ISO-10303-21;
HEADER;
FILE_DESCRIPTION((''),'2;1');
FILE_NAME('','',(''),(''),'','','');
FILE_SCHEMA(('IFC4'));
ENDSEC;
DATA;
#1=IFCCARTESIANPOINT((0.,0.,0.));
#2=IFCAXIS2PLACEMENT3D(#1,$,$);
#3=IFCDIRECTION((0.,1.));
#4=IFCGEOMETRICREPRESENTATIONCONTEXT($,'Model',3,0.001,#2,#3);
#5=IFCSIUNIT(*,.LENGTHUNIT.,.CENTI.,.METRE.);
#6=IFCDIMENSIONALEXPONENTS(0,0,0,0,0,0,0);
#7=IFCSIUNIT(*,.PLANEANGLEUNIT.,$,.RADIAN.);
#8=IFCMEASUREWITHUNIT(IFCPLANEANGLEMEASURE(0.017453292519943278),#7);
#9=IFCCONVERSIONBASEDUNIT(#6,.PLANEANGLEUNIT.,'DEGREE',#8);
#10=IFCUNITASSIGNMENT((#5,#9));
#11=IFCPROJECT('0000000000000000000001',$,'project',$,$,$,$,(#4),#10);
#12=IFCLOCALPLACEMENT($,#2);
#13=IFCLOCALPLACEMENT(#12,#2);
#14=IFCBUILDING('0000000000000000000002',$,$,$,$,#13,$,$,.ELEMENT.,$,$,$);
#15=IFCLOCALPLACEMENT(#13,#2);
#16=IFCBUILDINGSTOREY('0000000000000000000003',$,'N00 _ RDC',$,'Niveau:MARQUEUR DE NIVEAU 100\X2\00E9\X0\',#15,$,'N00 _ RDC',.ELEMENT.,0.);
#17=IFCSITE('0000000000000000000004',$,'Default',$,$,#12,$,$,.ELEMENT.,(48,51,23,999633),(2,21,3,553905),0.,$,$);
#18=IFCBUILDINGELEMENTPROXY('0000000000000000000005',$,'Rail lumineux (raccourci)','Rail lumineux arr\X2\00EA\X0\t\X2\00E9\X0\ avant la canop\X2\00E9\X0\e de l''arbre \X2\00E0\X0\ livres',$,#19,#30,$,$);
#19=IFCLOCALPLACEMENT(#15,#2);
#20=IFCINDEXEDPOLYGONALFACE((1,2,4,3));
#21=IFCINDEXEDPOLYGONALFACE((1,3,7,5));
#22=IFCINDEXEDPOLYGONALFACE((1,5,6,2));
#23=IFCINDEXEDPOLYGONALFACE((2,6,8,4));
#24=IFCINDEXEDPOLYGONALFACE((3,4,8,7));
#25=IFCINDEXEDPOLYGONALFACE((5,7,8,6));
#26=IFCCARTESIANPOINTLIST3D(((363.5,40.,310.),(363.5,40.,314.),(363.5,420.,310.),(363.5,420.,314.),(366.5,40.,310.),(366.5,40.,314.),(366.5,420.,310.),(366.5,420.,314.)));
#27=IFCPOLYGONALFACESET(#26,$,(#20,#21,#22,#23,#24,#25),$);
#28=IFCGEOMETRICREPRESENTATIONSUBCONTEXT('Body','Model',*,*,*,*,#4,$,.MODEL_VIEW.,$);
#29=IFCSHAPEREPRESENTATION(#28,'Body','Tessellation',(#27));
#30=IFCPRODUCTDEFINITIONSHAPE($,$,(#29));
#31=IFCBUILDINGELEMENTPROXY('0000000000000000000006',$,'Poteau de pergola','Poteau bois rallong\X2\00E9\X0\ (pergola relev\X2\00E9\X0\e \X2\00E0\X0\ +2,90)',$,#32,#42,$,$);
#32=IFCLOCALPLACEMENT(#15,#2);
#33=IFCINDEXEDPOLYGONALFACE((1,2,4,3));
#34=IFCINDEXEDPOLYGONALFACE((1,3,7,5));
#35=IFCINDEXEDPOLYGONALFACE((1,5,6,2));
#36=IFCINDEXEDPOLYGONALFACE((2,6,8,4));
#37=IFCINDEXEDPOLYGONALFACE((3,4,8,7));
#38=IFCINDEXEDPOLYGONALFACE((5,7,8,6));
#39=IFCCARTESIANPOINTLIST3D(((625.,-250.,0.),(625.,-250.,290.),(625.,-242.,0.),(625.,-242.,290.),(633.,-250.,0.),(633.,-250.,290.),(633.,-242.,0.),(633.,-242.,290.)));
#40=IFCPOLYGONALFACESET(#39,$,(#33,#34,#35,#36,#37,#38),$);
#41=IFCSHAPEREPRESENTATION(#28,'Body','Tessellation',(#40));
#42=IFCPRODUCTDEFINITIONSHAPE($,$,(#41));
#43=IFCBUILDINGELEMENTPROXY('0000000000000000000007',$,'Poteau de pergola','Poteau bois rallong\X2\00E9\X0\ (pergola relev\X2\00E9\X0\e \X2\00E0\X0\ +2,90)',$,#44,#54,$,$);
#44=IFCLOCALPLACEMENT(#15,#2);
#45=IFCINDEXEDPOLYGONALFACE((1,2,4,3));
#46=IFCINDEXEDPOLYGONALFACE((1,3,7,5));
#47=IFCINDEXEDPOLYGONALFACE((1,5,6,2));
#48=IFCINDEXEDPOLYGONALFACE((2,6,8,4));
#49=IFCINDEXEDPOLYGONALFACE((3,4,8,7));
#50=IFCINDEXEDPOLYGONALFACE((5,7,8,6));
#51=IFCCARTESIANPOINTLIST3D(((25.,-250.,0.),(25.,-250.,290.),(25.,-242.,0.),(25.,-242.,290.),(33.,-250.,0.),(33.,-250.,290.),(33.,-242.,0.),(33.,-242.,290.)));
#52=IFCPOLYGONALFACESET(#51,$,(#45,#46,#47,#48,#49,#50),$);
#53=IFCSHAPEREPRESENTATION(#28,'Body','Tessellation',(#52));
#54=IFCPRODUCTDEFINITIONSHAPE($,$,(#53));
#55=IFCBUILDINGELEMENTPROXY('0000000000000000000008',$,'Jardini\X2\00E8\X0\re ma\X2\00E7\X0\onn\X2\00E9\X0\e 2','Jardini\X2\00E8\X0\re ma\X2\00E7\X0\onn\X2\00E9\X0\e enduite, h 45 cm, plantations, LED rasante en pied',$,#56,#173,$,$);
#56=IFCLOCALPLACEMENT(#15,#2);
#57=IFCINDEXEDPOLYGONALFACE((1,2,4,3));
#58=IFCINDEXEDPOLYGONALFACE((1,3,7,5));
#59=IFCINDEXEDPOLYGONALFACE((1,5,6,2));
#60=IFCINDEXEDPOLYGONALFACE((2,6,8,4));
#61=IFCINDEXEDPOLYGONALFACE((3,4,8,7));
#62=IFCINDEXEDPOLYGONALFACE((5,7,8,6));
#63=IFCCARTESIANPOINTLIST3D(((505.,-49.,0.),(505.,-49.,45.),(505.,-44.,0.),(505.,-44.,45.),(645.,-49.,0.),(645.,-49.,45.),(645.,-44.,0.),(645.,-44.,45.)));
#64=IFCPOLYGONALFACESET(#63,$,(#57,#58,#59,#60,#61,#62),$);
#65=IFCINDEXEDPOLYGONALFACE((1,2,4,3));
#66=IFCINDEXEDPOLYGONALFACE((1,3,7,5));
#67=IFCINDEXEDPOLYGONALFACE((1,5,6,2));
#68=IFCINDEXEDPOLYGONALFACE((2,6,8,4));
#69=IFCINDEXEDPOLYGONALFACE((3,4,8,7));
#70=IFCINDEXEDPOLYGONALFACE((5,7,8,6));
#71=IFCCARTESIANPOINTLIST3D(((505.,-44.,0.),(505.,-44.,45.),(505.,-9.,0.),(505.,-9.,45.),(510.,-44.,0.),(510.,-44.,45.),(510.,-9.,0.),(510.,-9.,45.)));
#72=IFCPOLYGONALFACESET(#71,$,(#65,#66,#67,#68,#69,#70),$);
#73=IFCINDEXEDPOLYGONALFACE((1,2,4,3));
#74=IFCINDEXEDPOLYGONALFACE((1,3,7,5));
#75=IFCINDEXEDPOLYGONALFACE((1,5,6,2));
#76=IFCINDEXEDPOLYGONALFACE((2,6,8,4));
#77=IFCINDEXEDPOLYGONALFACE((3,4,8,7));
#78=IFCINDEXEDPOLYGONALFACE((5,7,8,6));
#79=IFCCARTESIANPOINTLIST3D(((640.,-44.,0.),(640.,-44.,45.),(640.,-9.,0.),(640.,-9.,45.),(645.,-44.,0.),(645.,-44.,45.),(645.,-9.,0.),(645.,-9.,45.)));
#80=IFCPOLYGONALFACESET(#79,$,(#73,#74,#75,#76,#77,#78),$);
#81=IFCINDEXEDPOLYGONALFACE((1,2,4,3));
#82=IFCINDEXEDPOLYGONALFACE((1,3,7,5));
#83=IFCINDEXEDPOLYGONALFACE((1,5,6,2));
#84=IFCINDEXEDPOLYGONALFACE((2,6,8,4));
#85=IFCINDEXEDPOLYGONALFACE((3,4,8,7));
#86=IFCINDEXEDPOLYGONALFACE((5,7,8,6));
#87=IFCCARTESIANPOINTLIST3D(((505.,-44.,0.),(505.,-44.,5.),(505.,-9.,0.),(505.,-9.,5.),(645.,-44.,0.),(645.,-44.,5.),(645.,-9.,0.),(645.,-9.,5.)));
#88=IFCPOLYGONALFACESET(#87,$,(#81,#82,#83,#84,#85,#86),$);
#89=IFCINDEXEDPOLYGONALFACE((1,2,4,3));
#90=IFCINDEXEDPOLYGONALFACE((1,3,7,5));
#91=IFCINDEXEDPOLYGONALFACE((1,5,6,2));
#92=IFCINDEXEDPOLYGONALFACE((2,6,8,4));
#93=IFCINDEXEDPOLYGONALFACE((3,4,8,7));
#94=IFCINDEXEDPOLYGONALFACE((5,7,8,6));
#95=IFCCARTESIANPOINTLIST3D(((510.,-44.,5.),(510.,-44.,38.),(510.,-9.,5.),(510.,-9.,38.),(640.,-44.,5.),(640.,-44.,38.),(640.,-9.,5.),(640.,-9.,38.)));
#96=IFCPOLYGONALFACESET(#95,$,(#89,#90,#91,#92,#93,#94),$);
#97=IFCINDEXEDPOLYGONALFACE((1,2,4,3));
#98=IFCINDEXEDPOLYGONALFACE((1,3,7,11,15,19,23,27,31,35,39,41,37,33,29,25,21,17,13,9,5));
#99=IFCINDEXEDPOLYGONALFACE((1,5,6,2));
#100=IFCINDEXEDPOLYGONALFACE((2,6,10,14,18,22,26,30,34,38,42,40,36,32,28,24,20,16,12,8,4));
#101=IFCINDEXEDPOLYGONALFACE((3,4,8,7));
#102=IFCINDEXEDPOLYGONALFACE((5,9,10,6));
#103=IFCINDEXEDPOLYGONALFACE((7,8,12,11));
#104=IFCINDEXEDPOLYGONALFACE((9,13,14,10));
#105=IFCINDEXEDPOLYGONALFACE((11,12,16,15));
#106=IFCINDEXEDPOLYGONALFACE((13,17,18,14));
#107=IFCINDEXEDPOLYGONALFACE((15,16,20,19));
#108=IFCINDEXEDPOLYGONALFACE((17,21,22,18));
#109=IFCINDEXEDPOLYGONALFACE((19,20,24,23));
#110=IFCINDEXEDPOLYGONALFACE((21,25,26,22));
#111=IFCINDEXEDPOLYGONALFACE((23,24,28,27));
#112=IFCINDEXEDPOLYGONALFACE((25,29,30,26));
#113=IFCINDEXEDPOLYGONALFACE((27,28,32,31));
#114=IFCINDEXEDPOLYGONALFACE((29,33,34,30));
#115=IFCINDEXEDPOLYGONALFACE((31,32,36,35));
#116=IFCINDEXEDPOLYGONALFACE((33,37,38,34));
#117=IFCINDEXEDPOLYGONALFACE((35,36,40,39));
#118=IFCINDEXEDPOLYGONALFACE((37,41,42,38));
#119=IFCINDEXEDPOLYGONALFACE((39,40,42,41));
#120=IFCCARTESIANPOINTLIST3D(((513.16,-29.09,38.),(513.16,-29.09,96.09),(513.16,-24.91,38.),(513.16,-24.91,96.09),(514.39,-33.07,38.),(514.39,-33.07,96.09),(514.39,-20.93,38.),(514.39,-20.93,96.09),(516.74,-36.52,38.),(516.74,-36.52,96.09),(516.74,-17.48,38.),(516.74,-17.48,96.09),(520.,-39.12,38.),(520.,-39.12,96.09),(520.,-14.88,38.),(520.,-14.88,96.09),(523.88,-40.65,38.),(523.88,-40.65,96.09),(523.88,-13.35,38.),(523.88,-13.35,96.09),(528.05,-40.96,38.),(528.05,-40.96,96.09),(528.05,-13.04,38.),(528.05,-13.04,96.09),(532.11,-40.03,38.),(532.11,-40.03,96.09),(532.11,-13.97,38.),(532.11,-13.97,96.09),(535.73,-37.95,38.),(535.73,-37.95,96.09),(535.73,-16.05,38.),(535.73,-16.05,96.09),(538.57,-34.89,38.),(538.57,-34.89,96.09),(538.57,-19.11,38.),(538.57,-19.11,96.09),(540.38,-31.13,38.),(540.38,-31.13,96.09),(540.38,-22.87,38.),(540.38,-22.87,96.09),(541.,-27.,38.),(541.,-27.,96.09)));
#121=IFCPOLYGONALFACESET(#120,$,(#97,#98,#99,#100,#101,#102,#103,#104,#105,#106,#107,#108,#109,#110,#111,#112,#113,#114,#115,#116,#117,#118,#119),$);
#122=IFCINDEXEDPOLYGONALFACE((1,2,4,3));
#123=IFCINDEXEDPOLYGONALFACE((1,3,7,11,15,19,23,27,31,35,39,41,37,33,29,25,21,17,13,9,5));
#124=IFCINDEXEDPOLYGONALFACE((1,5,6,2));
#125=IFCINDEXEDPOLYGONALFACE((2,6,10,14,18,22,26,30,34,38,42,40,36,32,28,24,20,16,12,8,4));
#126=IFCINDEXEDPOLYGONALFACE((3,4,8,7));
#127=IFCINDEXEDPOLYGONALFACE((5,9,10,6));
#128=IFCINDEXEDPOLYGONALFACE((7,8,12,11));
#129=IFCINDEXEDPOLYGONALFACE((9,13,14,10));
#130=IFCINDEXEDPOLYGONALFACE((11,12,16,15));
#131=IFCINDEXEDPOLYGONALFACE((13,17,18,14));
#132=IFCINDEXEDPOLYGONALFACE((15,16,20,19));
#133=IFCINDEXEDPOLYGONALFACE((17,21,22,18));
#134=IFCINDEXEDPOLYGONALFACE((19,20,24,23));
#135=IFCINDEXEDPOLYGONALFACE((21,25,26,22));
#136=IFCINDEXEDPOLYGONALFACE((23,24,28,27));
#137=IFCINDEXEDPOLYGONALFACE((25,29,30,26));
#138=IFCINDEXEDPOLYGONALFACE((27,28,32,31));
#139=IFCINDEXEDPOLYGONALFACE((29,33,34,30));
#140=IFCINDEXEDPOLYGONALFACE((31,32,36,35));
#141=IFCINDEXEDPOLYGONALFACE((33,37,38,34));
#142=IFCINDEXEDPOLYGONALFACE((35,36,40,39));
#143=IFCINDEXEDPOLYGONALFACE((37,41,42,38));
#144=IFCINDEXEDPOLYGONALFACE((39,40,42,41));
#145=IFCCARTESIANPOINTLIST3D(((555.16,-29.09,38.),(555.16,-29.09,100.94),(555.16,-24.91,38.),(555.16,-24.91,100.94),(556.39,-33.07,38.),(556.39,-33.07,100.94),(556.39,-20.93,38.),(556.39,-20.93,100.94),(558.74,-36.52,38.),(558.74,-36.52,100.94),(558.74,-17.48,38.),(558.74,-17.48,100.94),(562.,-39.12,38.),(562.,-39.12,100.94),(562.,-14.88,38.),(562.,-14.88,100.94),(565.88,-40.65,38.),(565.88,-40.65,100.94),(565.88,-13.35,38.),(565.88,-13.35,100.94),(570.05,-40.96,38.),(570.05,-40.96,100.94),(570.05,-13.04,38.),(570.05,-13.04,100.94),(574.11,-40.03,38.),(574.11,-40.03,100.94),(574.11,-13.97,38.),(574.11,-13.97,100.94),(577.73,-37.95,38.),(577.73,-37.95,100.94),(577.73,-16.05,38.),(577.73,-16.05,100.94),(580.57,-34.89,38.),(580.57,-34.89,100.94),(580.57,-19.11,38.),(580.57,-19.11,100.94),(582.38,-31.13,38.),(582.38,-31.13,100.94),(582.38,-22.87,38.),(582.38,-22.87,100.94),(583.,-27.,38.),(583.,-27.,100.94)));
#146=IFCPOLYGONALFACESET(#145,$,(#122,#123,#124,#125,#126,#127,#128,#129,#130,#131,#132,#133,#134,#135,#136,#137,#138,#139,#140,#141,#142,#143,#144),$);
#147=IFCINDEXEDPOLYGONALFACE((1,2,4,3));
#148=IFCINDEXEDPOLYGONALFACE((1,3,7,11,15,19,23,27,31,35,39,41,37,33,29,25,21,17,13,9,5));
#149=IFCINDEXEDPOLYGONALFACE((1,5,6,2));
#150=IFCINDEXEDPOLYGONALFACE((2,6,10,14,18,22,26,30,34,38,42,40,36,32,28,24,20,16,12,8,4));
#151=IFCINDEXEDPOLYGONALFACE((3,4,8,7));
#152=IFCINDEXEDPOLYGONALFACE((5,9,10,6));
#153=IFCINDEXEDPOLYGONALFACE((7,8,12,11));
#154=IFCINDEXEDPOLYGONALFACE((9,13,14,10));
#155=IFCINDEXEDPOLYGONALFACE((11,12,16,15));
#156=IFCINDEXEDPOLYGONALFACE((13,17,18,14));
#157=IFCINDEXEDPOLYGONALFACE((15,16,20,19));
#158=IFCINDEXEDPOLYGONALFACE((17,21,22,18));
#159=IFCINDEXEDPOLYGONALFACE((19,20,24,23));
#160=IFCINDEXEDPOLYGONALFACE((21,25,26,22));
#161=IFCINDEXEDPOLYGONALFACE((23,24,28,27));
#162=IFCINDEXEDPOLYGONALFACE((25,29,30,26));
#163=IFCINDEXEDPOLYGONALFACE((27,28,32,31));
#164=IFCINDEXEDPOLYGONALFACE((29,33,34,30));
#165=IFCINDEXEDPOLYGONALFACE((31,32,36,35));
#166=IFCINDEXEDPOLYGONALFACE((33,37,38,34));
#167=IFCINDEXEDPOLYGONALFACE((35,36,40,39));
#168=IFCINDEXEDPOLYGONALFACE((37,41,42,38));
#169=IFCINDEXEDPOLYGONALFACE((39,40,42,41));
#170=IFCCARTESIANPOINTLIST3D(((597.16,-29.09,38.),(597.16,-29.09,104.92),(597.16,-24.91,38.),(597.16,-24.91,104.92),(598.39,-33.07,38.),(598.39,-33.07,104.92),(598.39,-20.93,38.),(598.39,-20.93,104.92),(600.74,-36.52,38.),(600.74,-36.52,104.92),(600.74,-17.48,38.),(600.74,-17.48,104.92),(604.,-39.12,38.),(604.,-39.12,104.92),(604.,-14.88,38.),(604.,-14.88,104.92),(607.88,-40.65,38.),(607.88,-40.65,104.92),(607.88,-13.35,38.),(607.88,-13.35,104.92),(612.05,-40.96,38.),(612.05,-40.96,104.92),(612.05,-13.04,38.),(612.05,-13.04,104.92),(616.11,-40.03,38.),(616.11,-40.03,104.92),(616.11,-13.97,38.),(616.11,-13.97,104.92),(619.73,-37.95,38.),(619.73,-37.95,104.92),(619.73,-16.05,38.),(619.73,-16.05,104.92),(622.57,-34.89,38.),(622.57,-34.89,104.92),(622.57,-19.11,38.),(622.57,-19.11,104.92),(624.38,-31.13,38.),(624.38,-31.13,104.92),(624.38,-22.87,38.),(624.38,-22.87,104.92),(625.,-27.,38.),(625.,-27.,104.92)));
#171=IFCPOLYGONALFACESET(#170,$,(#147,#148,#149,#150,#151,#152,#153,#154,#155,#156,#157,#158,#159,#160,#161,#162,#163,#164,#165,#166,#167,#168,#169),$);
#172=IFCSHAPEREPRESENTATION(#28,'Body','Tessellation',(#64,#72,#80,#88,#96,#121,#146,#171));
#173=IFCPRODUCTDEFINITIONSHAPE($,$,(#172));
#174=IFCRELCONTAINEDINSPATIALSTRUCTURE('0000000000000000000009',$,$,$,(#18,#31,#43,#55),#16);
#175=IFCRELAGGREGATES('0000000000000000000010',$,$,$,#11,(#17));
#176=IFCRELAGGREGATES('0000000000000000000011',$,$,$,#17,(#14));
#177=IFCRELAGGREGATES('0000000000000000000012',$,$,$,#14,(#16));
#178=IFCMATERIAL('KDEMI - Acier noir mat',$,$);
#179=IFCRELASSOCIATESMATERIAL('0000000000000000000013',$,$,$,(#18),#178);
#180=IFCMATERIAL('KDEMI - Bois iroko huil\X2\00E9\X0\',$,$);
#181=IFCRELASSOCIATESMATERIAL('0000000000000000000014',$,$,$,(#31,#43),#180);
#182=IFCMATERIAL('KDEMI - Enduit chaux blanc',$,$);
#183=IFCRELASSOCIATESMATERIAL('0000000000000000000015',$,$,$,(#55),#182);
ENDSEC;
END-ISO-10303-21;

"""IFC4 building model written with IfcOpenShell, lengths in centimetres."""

from ifc_helpers import new_model, entity, si_unit, converted_unit, direction, frame, frame_2d, origin, origin_with_axes, place, context, subcontext, project, spatial, rectangle, circle, extrude, material, element, save


model = new_model("IFC4")

# Units and contexts
model_context = context("Model", 3, precision=0.001, world=origin(), true_north=direction((0.0, 1.0)))
body_context = subcontext(model_context, "Body", "Model", "MODEL_VIEW")
ifc_project = project(units=[si_unit("LENGTHUNIT", "METRE", prefix="CENTI"), converted_unit("PLANEANGLEUNIT", "DEGREE", entity("IfcPlaneAngleMeasure", 0.017453292519943278), si_unit("PLANEANGLEUNIT", "RADIAN"), dimensions=[0, 0, 0, 0, 0, 0, 0])], contexts=[model_context])

# Site, building, storey
site_placement = place(None, origin())
site = spatial("IfcSite", under=ifc_project, at=site_placement, Name="Default", CompositionType="ELEMENT", RefLatitude=(48, 51, 23, 999633), RefLongitude=(2, 21, 3, 553905), RefElevation=0.0)
building_placement = place(site_placement, origin())
building = spatial("IfcBuilding", under=site, at=building_placement, CompositionType="ELEMENT")
storey_placement = place(building_placement, origin())
storey = spatial("IfcBuildingStorey", under=building, at=storey_placement, Name="N00 _ RDC", ObjectType="Niveau:MARQUEUR DE NIVEAU 100é", LongName="N00 _ RDC", CompositionType="ELEMENT", Elevation=0.0)

# Shared definitions
ifc_material_1 = material(Name="KDEMI - Acier noir mat")

# Shared definitions
ifc_material_2 = material(Name="KDEMI - Bois iroko huilé")

# Building element proxies
proxy_1_placement = place(storey_placement, origin_with_axes())
element("IfcBuildingElementProxy", 1, at=proxy_1_placement, inside=storey, material=ifc_material_1, Name="Rail lumineux (raccourci)", Description="Rail lumineux arrêté avant la canopée de l'arbre à livres", context=body_context, shape_type="SweptSolid", body=[
    extrude(rectangle(XDim=3.0, YDim=380.0, at=frame_2d((365.0, 230.0))), frame((0.0, 0.0, 310.0)), (0.0, 0.0, 1.0), 4.0),
])
proxy_2_placement = place(storey_placement, origin_with_axes())
element("IfcBuildingElementProxy", 2, at=proxy_2_placement, inside=storey, material=ifc_material_2, Name="Poteau de pergola", Description="Poteau bois rallongé (pergola relevée à +2,90)", context=body_context, shape_type="SweptSolid", body=[
    extrude(rectangle(XDim=8.0, YDim=8.0, at=frame_2d((629.0, -246.0))), origin(), (0.0, 0.0, 1.0), 290.0),
])
proxy_3_placement = place(storey_placement, origin_with_axes())
element("IfcBuildingElementProxy", 3, at=proxy_3_placement, inside=storey, material=ifc_material_2, Name="Poteau de pergola", Description="Poteau bois rallongé (pergola relevée à +2,90)", context=body_context, shape_type="SweptSolid", body=[
    extrude(rectangle(XDim=8.0, YDim=8.0, at=frame_2d((29.0, -246.0))), origin(), (0.0, 0.0, 1.0), 290.0),
])
ifc_material_3 = material(Name="KDEMI - Enduit chaux blanc")
proxy_4_placement = place(storey_placement, origin_with_axes())
element("IfcBuildingElementProxy", 4, at=proxy_4_placement, inside=storey, material=ifc_material_3, Name="Jardinière maçonnée 2", Description="Jardinière maçonnée enduite, h 45 cm, plantations, LED rasante en pied", context=body_context, shape_type="SweptSolid", body=[
    extrude(rectangle(XDim=140.0, YDim=5.0, at=frame_2d((575.0, -46.5))), origin(), (0.0, 0.0, 1.0), 45.0),
    extrude(rectangle(XDim=5.0, YDim=35.0, at=frame_2d((507.5, -26.5))), origin(), (0.0, 0.0, 1.0), 45.0),
    extrude(rectangle(XDim=5.0, YDim=35.0, at=frame_2d((642.5, -26.5))), origin(), (0.0, 0.0, 1.0), 45.0),
    extrude(rectangle(XDim=140.0, YDim=35.0, at=frame_2d((575.0, -26.5))), origin(), (0.0, 0.0, 1.0), 5.0),
    extrude(rectangle(XDim=130.0, YDim=35.0, at=frame_2d((575.0, -26.5))), frame((0.0, 0.0, 5.0)), (0.0, 0.0, 1.0), 33.0),
    extrude(circle(Radius=14.0, at=frame_2d((527.0, -27.0))), frame((0.0, 0.0, 38.0)), (0.0, 0.0, 1.0), 58.09),
    extrude(circle(Radius=14.0, at=frame_2d((569.0, -27.0))), frame((0.0, 0.0, 38.0)), (0.0, 0.0, 1.0), 62.94),
    extrude(circle(Radius=14.0, at=frame_2d((611.0, -27.0))), frame((0.0, 0.0, 38.0)), (0.0, 0.0, 1.0), 66.92),
])

save(model, "model.ifc")
